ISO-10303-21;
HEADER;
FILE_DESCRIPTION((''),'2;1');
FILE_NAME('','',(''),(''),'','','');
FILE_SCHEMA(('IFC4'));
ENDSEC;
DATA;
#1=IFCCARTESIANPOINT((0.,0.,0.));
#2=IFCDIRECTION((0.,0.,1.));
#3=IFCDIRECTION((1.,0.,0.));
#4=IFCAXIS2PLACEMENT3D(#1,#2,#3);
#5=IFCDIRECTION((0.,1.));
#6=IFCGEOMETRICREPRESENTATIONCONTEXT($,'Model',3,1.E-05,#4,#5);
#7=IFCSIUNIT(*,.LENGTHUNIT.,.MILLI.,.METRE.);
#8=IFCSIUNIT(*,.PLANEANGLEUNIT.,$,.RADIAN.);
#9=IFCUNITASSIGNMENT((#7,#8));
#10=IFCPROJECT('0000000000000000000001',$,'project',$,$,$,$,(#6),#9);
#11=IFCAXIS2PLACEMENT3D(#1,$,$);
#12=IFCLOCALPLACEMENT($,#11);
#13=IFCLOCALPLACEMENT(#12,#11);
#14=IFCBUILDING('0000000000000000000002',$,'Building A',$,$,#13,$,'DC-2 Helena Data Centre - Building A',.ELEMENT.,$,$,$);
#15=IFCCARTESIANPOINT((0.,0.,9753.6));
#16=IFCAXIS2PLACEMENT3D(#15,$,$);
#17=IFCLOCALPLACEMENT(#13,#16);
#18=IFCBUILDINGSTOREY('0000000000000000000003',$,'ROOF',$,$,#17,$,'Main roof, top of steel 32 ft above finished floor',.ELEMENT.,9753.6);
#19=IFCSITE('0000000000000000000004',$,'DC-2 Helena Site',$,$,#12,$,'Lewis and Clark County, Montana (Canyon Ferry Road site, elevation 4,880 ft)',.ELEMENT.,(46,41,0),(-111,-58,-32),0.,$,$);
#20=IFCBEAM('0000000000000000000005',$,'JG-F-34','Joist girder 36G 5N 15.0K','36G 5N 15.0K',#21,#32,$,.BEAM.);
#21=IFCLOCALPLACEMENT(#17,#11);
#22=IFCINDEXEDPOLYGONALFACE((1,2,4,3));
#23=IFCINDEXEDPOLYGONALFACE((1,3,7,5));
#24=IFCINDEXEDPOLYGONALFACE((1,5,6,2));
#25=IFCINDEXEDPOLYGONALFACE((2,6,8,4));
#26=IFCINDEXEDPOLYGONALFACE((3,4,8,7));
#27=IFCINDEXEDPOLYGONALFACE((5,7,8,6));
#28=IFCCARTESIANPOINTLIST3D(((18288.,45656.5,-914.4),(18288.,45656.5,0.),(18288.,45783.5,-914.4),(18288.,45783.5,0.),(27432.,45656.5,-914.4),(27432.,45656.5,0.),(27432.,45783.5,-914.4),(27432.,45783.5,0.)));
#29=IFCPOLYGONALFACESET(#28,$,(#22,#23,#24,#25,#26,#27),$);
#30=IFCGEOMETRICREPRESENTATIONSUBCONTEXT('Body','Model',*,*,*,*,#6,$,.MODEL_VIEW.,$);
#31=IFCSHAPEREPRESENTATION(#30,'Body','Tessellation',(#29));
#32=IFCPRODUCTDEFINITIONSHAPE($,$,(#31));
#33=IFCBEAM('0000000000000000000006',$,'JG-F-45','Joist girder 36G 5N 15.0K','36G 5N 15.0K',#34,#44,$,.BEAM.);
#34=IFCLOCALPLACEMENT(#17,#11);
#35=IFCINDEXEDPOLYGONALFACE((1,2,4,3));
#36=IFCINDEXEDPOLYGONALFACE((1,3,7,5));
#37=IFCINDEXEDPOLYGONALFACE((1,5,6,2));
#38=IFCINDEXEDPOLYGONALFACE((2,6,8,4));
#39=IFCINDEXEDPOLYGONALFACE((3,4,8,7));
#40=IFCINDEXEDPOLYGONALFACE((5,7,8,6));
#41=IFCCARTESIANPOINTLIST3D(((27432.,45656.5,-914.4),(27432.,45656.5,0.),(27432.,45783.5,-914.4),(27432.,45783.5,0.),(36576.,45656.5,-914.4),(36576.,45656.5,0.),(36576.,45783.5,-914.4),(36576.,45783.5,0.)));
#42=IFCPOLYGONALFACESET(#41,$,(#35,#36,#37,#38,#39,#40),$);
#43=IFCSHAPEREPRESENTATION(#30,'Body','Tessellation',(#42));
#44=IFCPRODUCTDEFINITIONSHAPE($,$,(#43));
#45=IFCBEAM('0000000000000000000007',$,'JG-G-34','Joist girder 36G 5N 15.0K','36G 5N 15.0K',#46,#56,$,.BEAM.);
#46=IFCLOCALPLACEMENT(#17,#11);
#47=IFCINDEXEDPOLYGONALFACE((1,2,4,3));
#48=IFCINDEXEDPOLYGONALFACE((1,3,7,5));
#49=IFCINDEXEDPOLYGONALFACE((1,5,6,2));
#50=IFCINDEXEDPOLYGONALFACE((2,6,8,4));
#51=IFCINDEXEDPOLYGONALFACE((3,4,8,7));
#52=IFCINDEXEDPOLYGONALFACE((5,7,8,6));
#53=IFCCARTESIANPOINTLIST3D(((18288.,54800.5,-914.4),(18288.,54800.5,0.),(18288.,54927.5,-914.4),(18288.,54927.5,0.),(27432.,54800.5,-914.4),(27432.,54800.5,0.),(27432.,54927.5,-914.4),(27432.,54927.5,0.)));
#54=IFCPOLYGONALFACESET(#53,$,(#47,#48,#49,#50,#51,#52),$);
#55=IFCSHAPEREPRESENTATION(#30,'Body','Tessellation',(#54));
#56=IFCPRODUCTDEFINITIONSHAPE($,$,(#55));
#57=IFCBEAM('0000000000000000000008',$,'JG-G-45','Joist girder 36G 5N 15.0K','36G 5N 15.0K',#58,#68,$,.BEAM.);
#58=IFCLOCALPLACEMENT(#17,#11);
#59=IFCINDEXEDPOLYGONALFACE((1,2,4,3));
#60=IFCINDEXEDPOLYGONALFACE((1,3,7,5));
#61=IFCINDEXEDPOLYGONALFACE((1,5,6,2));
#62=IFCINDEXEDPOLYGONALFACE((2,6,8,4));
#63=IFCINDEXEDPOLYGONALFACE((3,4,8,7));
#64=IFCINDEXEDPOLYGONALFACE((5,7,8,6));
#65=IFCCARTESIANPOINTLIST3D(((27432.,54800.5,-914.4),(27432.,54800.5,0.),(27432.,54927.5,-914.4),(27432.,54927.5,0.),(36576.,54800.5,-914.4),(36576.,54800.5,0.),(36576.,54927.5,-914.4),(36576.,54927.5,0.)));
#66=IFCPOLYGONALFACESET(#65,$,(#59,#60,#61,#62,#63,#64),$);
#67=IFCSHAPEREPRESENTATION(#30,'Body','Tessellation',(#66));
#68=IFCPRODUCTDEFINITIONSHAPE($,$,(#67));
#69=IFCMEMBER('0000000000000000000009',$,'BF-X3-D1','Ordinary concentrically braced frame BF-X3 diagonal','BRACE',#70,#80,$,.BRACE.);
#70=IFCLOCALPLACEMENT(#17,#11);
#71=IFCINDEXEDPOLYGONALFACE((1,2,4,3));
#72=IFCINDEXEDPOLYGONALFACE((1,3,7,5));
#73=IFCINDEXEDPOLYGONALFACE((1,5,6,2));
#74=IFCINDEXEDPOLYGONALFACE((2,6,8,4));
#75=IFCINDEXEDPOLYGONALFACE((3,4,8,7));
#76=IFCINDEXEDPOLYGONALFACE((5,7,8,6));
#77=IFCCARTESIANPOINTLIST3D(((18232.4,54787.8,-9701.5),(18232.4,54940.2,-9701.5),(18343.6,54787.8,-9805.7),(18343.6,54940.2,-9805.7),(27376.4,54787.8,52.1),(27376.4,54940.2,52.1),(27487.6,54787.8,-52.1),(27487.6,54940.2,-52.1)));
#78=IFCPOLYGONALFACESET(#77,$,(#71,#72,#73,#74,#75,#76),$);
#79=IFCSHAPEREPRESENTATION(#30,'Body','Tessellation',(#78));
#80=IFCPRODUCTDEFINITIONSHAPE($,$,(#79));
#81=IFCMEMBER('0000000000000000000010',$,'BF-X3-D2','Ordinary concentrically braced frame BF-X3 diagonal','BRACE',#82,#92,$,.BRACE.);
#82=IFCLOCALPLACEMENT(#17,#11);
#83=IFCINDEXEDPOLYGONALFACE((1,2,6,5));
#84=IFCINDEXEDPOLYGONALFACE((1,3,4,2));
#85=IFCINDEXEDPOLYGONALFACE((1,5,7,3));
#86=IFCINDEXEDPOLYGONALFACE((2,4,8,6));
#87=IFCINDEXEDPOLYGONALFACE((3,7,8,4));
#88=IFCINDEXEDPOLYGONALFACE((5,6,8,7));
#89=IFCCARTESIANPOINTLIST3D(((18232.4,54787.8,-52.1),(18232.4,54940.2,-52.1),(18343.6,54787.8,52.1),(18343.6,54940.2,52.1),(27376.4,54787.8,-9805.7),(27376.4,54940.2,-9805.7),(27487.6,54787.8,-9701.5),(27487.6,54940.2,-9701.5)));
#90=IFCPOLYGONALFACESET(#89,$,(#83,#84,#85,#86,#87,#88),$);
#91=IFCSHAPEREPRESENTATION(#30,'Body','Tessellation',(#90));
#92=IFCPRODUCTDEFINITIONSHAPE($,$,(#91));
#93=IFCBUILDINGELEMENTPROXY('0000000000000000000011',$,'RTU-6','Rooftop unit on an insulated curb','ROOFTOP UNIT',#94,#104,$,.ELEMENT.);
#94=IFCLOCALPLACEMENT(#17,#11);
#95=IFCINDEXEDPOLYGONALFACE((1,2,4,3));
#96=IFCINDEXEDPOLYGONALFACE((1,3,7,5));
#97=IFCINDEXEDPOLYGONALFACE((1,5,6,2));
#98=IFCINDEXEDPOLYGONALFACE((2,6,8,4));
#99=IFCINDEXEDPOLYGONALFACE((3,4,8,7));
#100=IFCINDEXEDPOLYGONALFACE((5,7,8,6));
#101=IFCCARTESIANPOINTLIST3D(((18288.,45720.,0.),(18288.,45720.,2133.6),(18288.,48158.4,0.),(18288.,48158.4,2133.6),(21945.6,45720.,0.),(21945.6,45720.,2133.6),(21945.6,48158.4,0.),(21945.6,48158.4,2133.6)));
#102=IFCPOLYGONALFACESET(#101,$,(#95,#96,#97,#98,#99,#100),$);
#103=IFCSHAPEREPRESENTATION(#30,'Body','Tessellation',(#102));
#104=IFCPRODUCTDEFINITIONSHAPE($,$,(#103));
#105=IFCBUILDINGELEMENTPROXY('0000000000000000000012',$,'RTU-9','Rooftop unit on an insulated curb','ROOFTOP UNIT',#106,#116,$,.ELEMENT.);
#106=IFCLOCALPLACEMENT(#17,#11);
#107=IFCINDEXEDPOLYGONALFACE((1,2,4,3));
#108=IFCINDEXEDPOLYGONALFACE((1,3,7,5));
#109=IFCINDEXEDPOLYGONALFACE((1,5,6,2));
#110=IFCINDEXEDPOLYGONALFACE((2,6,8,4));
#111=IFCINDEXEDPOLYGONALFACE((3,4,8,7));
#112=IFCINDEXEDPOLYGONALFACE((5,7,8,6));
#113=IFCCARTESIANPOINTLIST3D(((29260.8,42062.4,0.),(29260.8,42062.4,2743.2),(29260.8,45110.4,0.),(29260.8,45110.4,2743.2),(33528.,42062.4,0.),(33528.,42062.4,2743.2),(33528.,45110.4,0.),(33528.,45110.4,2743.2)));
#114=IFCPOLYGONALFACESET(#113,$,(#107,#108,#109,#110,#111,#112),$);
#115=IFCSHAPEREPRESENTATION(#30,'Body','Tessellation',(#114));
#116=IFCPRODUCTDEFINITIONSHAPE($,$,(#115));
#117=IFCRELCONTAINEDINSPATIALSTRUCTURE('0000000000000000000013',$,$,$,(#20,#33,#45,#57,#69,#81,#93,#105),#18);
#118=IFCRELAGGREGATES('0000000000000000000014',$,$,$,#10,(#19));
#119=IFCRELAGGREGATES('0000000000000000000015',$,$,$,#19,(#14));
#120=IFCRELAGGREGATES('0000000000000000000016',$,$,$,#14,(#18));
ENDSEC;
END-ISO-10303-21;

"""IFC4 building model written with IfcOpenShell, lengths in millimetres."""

from ifc_helpers import new_model, si_unit, direction, frame, origin, origin_with_axes, origin_2d, place, context, subcontext, project, spatial, rectangle, extrude, element, save


model = new_model("IFC4")

# Units and contexts
model_context = context("Model", 3, precision=1e-05, world=origin_with_axes(), true_north=direction((0.0, 1.0)))
body_context = subcontext(model_context, "Body", "Model", "MODEL_VIEW")
ifc_project = project(units=[si_unit("LENGTHUNIT", "METRE", prefix="MILLI"), si_unit("PLANEANGLEUNIT", "RADIAN")], contexts=[model_context])

# Site, building, storey
site_placement = place(None, origin())
site = spatial("IfcSite", under=ifc_project, at=site_placement, Name="DC-2 Helena Site", LongName="Lewis and Clark County, Montana (Canyon Ferry Road site, elevation 4,880 ft)", CompositionType="ELEMENT", RefLatitude=(46, 41, 0), RefLongitude=(-111, -58, -32), RefElevation=0.0)
building_placement = place(site_placement, origin())
building = spatial("IfcBuilding", under=site, at=building_placement, Name="Building A", LongName="DC-2 Helena Data Centre - Building A", CompositionType="ELEMENT")
storey_placement = place(building_placement, frame((0.0, 0.0, 9753.6)))
storey = spatial("IfcBuildingStorey", under=building, at=storey_placement, Name="ROOF", LongName="Main roof, top of steel 32 ft above finished floor", CompositionType="ELEMENT", Elevation=9753.6)

# Shared definitions
placement_1 = place(storey_placement, frame((18288.0, 54864.0, -9753.6)))
placement_2 = place(storey_placement, frame((27432.0, 54864.0, -9753.6)))

# Beams
placement_3 = place(storey_placement, frame((18288.0, 45720.0, 0.0)))
placement_4 = place(storey_placement, frame((27432.0, 45720.0, 0.0)))
element("IfcBeam", 1, at=placement_3, inside=storey, Name="JG-F-34", Description="Joist girder 36G 5N 15.0K", ObjectType="36G 5N 15.0K", PredefinedType="BEAM", context=body_context, shape_type="SweptSolid", body=[
    extrude(rectangle(XDim=127.0, YDim=914.4, at=origin_2d()), frame((0.0, 0.0, -457.2), z_axis=(1.0, 0.0, 0.0), x_axis=(0.0, 1.0, 0.0)), (0.0, 0.0, 1.0), 9144.0),
])
element("IfcBeam", 2, at=placement_4, inside=storey, Name="JG-F-45", Description="Joist girder 36G 5N 15.0K", ObjectType="36G 5N 15.0K", PredefinedType="BEAM", context=body_context, shape_type="SweptSolid", body=[
    extrude(rectangle(XDim=127.0, YDim=914.4, at=origin_2d()), frame((0.0, 0.0, -457.2), z_axis=(1.0, 0.0, 0.0), x_axis=(0.0, 1.0, 0.0)), (0.0, 0.0, 1.0), 9144.0),
])
for number, where, name in (
    (3, (18288.0, 54864.0, 0.0), "JG-G-34"),
    (4, (27432.0, 54864.0, 0.0), "JG-G-45"),
):
    element("IfcBeam", number, at=place(storey_placement, frame(where)), inside=storey, Name=name, Description="Joist girder 36G 5N 15.0K", ObjectType="36G 5N 15.0K", PredefinedType="BEAM", context=body_context, shape_type="SweptSolid", body=[
        extrude(rectangle(XDim=127.0, YDim=914.4, at=origin_2d()), frame((0.0, 0.0, -457.2), z_axis=(1.0, 0.0, 0.0), x_axis=(0.0, 1.0, 0.0)), (0.0, 0.0, 1.0), 9144.0),
    ])

# Members
element("IfcMember", 5, at=placement_1, inside=storey, Name="BF-X3-D1", Description="Ordinary concentrically braced frame BF-X3 diagonal", ObjectType="BRACE", PredefinedType="BRACE", context=body_context, shape_type="SweptSolid", body=[
    extrude(rectangle(XDim=152.4, YDim=152.4, at=origin_2d()), frame((0.0, 0.0, 0.0), z_axis=(0.683941, 0.0, 0.729537), x_axis=(0.0, 1.0, 0.0)), (0.0, 0.0, 1.0), 13369.6),
])
element("IfcMember", 6, at=placement_2, inside=storey, Name="BF-X3-D2", Description="Ordinary concentrically braced frame BF-X3 diagonal", ObjectType="BRACE", PredefinedType="BRACE", context=body_context, shape_type="SweptSolid", body=[
    extrude(rectangle(XDim=152.4, YDim=152.4, at=origin_2d()), frame((0.0, 0.0, 0.0), z_axis=(-0.683941, 0.0, 0.729537), x_axis=(0.0, 1.0, 0.0)), (0.0, 0.0, 1.0), 13369.6),
])

# Building element proxies
proxy_1_placement = place(storey_placement, frame((20116.8, 46939.2, 0.0)))
element("IfcBuildingElementProxy", 7, at=proxy_1_placement, inside=storey, Name="RTU-6", Description="Rooftop unit on an insulated curb", ObjectType="ROOFTOP UNIT", PredefinedType="ELEMENT", context=body_context, shape_type="SweptSolid", body=[
    extrude(rectangle(XDim=3657.6, YDim=2438.4, at=origin_2d()), origin(), (0.0, 0.0, 1.0), 2133.6),
])
proxy_2_placement = place(storey_placement, frame((31394.4, 43586.4, 0.0)))
element("IfcBuildingElementProxy", 8, at=proxy_2_placement, inside=storey, Name="RTU-9", Description="Rooftop unit on an insulated curb", ObjectType="ROOFTOP UNIT", PredefinedType="ELEMENT", context=body_context, shape_type="SweptSolid", body=[
    extrude(rectangle(XDim=4267.2, YDim=3048.0, at=origin_2d()), origin(), (0.0, 0.0, 1.0), 2743.2),
])

save(model, "model.ifc")
